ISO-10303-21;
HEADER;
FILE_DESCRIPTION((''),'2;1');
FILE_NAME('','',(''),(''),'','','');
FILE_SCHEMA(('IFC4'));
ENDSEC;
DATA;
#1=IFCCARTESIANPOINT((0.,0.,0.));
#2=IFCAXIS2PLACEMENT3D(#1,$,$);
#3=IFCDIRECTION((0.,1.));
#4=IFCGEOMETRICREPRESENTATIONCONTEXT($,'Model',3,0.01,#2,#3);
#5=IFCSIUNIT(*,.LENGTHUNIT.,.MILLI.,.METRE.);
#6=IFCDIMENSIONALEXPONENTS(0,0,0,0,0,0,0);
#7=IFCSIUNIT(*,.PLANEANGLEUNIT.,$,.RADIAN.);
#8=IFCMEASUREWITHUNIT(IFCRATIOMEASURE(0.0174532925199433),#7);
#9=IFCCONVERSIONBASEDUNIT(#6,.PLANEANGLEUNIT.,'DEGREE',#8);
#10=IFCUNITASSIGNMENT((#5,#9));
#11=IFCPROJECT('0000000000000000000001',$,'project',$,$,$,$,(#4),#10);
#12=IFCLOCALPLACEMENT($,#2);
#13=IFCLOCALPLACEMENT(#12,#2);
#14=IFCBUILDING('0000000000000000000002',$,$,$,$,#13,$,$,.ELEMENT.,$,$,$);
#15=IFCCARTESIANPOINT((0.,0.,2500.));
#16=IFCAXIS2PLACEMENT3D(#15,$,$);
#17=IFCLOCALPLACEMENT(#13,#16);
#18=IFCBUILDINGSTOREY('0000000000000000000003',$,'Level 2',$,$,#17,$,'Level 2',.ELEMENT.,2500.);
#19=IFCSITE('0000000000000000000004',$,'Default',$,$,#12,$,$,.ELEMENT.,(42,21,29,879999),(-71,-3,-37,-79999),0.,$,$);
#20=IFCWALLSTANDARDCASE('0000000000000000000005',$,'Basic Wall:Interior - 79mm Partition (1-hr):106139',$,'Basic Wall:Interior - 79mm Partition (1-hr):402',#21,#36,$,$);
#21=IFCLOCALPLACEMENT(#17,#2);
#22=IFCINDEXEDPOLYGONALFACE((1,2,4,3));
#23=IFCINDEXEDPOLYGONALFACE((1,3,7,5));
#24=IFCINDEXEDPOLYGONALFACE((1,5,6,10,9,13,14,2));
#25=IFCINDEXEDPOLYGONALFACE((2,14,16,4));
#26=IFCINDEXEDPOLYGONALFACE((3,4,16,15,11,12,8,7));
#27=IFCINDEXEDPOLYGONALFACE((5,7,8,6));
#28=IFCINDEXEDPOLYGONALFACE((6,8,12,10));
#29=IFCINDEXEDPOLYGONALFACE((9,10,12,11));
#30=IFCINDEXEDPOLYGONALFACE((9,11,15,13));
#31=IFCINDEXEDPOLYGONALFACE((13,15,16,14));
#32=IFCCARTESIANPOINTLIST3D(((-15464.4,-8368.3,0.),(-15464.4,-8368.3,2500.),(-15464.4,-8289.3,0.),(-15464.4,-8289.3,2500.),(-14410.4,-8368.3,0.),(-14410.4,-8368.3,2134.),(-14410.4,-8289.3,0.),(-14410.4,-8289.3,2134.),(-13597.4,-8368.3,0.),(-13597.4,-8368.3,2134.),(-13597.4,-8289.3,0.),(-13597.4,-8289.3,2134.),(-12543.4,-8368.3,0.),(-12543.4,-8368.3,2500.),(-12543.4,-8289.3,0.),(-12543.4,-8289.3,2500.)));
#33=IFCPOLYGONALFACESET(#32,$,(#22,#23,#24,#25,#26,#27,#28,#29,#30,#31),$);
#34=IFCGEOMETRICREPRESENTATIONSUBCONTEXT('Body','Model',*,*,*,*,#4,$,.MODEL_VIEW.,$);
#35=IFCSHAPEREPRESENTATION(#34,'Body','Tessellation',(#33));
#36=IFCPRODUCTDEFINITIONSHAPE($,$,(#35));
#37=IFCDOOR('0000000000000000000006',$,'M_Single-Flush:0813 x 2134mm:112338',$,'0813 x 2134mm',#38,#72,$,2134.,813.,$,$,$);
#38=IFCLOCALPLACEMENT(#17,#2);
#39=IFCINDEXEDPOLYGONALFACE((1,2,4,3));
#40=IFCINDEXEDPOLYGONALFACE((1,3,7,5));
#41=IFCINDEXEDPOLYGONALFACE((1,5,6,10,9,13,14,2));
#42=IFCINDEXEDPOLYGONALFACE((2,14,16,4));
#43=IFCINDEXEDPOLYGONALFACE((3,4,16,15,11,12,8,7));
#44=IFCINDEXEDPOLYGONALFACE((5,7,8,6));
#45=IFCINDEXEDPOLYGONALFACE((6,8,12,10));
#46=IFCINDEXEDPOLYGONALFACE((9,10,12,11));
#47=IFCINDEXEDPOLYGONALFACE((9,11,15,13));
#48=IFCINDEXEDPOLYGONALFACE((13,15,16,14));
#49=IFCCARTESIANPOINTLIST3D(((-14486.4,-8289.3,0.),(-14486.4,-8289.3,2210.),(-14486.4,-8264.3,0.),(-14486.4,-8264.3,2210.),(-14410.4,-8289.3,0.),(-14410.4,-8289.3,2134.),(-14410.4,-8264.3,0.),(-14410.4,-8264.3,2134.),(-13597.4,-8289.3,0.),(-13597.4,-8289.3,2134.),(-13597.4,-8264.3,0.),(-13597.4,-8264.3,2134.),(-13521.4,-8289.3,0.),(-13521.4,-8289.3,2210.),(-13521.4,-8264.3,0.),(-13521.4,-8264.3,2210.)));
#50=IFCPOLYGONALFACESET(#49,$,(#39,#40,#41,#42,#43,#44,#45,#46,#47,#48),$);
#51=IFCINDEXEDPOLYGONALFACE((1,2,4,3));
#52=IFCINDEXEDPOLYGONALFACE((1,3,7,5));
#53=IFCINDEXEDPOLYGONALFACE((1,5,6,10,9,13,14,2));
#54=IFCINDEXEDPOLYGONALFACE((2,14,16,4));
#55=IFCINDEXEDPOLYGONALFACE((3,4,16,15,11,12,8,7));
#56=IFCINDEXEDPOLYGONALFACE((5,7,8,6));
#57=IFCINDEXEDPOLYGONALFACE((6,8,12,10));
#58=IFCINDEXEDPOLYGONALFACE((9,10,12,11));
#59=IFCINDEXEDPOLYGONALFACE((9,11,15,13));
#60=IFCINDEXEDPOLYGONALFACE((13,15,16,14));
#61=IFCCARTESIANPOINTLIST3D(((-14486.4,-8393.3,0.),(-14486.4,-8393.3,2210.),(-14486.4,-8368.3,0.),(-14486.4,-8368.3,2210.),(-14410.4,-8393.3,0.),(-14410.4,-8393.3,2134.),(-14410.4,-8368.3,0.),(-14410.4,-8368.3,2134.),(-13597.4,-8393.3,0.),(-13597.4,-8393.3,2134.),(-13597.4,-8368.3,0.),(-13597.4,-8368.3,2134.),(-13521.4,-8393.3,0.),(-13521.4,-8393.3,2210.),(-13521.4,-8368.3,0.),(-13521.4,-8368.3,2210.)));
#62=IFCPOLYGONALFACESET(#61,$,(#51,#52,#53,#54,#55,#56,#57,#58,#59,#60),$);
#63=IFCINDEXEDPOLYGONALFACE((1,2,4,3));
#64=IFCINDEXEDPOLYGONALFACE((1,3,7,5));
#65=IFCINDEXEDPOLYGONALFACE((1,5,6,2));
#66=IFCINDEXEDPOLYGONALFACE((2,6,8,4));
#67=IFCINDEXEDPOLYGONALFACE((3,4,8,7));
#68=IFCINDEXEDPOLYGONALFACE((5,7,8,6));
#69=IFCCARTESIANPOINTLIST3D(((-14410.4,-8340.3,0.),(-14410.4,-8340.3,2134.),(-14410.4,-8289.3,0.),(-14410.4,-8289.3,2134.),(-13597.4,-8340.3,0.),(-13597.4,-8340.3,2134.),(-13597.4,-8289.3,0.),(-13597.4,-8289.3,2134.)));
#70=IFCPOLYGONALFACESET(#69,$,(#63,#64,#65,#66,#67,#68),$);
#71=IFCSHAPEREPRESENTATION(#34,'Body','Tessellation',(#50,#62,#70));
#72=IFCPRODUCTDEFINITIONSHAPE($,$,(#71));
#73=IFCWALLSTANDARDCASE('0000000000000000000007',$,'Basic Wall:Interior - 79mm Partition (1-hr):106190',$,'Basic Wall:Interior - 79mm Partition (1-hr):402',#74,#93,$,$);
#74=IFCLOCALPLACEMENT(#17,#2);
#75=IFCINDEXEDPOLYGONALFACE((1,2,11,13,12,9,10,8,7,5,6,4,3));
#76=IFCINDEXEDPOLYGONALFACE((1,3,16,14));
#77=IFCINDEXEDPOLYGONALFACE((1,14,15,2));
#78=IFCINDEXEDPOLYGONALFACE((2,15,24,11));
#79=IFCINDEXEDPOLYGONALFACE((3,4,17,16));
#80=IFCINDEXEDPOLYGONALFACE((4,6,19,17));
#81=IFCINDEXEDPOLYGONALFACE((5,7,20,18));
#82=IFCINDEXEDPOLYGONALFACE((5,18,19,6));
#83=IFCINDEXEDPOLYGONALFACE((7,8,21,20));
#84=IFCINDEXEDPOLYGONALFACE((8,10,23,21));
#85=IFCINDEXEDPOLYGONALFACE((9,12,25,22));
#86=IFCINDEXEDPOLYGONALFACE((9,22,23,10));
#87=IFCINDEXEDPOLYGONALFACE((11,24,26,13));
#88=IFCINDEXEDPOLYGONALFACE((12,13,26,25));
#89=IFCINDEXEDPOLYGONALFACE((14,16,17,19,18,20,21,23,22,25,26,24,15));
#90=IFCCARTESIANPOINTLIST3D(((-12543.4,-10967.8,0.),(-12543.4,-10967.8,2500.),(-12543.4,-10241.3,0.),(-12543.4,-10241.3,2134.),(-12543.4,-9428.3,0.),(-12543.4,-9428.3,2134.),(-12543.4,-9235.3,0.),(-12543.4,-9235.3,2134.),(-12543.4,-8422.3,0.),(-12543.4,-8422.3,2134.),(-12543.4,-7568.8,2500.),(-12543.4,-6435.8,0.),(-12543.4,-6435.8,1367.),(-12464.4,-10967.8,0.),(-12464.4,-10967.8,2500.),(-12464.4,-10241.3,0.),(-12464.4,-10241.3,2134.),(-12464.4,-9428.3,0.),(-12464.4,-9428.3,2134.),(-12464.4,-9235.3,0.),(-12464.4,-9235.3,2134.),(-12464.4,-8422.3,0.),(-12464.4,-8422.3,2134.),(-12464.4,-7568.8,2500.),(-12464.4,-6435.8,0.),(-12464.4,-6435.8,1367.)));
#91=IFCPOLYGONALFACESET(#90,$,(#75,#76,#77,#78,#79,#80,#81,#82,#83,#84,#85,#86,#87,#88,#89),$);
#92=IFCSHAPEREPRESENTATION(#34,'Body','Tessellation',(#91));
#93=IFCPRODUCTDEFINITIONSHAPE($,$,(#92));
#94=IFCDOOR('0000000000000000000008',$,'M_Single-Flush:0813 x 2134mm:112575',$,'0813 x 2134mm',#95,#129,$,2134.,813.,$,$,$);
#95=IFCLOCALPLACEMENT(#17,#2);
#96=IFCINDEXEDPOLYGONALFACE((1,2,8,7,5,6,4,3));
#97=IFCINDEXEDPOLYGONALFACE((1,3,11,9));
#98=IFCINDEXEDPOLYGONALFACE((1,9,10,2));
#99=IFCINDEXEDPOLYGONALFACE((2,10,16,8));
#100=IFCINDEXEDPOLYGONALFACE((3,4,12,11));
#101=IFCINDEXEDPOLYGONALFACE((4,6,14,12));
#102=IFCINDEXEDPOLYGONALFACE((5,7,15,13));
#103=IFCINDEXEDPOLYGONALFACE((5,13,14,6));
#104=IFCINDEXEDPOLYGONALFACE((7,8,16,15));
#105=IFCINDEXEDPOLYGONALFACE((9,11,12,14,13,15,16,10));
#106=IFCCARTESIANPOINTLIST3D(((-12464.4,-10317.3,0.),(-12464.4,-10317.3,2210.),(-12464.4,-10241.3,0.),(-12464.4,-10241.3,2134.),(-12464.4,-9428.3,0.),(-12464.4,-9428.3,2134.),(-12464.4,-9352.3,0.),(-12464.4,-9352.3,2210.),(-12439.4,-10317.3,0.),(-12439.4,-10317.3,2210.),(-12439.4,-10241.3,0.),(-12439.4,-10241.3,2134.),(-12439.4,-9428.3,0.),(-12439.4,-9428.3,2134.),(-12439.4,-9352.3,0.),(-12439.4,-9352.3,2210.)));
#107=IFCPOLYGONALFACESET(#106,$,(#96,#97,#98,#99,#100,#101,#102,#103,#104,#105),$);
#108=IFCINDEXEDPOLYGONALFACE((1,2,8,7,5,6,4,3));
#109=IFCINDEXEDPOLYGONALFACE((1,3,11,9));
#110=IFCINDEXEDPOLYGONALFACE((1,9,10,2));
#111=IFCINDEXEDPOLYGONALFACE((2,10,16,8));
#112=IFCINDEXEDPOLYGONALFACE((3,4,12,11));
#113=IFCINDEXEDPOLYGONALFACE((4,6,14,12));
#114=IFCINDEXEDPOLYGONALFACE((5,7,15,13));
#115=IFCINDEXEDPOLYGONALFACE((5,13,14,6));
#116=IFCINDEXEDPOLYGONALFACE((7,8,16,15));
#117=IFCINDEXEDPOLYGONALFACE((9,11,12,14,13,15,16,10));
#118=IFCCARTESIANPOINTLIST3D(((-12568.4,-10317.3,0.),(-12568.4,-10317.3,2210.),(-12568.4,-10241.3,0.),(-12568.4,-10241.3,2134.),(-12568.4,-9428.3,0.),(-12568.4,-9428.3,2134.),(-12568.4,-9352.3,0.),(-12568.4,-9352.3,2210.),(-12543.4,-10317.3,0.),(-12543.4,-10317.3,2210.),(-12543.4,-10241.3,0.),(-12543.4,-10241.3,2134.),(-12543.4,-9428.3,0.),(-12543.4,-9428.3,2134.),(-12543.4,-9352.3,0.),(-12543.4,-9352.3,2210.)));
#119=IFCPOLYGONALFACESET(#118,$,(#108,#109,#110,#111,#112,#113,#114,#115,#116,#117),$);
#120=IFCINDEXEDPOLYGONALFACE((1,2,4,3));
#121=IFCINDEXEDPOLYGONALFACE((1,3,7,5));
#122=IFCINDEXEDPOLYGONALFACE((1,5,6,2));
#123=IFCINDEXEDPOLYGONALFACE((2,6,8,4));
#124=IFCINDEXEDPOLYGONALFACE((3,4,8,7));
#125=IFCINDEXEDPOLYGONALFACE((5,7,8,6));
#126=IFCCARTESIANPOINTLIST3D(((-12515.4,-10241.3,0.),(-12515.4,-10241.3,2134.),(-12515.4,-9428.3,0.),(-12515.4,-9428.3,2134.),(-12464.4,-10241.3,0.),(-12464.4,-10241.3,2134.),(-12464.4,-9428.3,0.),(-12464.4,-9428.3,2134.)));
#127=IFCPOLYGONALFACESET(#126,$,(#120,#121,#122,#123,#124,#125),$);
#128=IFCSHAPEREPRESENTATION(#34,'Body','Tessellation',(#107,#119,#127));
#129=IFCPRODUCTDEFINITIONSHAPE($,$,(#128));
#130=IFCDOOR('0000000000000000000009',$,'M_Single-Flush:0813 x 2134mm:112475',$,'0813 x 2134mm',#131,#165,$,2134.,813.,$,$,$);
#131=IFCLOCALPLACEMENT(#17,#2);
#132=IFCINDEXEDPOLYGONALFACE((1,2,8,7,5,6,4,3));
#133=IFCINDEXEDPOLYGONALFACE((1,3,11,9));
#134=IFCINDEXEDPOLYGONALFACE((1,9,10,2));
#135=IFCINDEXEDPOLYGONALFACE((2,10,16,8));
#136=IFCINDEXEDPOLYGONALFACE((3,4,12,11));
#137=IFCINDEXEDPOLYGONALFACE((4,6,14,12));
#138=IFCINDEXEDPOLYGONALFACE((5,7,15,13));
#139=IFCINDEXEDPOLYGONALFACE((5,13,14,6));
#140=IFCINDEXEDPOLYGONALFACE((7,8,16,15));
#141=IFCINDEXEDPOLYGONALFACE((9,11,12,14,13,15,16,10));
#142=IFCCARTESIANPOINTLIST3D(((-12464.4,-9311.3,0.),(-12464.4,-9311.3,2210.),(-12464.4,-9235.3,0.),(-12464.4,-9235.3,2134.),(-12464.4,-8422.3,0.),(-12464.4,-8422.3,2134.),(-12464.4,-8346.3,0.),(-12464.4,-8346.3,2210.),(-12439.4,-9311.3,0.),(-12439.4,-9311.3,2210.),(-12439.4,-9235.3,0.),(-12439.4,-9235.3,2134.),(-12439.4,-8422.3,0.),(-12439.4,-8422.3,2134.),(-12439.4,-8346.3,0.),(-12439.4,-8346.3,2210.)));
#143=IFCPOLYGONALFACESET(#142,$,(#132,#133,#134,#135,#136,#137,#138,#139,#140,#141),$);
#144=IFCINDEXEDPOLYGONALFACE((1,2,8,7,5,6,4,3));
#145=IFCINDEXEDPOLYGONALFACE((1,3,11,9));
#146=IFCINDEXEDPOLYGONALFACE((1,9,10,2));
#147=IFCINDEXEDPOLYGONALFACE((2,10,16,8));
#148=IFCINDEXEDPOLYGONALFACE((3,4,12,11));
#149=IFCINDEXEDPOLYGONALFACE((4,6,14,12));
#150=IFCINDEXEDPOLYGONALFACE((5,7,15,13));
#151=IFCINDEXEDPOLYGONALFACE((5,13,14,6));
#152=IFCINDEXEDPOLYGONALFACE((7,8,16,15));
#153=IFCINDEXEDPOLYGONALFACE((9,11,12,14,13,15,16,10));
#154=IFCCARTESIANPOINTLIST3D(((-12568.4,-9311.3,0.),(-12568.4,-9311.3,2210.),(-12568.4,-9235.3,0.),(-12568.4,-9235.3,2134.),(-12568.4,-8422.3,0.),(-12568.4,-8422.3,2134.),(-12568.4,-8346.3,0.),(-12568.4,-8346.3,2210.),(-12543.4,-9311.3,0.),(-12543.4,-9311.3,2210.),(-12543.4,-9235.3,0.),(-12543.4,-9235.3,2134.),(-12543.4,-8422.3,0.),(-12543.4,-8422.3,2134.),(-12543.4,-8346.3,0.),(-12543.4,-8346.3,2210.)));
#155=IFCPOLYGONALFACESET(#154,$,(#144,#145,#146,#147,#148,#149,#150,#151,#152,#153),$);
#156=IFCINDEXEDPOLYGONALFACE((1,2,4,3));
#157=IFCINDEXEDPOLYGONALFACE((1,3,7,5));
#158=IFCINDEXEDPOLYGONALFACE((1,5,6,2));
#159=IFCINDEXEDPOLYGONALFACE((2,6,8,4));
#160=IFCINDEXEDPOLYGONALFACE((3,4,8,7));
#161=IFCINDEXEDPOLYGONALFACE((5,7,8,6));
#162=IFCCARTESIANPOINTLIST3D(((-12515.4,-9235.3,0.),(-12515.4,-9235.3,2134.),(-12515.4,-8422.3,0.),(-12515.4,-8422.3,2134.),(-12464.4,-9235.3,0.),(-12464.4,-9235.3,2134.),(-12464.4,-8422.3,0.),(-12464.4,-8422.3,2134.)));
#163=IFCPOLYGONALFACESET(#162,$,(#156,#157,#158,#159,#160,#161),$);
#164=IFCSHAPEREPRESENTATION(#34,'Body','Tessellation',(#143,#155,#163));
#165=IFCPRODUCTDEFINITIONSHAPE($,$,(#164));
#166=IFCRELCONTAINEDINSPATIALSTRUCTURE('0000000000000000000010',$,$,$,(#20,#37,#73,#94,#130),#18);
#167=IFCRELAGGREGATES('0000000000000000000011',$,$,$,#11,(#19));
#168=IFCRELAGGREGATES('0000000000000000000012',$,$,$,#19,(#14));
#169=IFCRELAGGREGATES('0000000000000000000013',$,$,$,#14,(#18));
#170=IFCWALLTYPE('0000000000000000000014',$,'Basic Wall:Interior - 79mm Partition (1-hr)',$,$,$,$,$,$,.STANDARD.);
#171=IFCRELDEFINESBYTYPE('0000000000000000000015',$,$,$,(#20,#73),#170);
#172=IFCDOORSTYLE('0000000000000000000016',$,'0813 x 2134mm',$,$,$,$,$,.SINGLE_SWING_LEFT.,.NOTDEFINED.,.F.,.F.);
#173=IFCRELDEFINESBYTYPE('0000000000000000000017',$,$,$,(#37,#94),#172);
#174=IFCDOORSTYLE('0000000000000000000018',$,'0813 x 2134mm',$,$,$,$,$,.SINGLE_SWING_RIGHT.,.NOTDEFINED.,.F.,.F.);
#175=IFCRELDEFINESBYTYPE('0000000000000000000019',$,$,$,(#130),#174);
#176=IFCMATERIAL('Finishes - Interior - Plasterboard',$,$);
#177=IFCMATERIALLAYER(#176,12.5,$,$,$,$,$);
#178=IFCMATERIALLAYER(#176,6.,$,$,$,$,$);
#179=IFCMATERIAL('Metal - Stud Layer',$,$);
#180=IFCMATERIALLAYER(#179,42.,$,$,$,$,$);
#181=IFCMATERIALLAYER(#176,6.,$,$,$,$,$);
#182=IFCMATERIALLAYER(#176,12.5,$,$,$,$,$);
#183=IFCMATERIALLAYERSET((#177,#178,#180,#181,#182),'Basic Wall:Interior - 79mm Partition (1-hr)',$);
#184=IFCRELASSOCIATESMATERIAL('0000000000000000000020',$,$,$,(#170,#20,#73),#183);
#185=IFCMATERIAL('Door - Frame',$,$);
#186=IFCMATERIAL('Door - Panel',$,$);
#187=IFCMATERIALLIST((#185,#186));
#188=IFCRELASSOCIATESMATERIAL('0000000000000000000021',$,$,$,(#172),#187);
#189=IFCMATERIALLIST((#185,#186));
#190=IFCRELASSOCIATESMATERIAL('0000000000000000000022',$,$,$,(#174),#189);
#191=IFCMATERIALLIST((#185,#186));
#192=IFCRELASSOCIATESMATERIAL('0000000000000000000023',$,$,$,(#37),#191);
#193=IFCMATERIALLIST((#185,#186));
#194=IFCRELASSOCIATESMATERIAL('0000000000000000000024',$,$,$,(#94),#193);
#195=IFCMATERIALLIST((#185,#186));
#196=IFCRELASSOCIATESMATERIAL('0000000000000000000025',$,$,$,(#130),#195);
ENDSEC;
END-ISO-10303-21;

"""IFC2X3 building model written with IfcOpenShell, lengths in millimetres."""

from ifc_helpers import new_model, entity, si_unit, converted_unit, direction, frame, frame_2d, origin, origin_2d_with_axis, place, context, subcontext, project, spatial, polyline, rectangle, outline, extrude, clip, halfspace, source, transform, mapped, material, material_list, layer, layer_set, layer_usage, type_object, type_shapes, element, fill, save


model = new_model("IFC2X3")

# Units and contexts
model_context = context("Model", 3, precision=0.01, world=origin(), true_north=direction((0.0, 1.0)))
body_context = subcontext(model_context, "Body", "Model", "MODEL_VIEW")
ifc_project = project(units=[si_unit("LENGTHUNIT", "METRE", prefix="MILLI"), converted_unit("PLANEANGLEUNIT", "DEGREE", entity("IfcRatioMeasure", 0.0174532925199433), si_unit("PLANEANGLEUNIT", "RADIAN"), dimensions=[0, 0, 0, 0, 0, 0, 0])], contexts=[model_context])

# Site, building, storey
site_placement = place(None, origin())
site = spatial("IfcSite", under=ifc_project, at=site_placement, Name="Default", CompositionType="ELEMENT", RefLatitude=(42, 21, 29, 879999), RefLongitude=(-71, -3, -37, -79999), RefElevation=0.0)
building_placement = place(site_placement, origin())
building = spatial("IfcBuilding", under=site, at=building_placement, CompositionType="ELEMENT")
storey_placement = place(building_placement, frame((0.0, 0.0, 2500.0)))
storey = spatial("IfcBuildingStorey", under=building, at=storey_placement, Name="Level 2", LongName="Level 2", CompositionType="ELEMENT", Elevation=2500.0)

# Shared definitions
ifc_material_1 = material(Name="Finishes - Interior - Plasterboard")
ifc_layer_1 = layer(ifc_material_1, 12.5)
ifc_layer_2 = layer(ifc_material_1, 6.0)
ifc_material_2 = material(Name="Metal - Stud Layer")
ifc_layer_3 = layer(ifc_material_2, 42.0)
ifc_layer_4 = layer(ifc_material_1, 6.0)
ifc_layer_5 = layer(ifc_material_1, 12.5)
ifc_layer_set_1 = layer_set([ifc_layer_1, ifc_layer_2, ifc_layer_3, ifc_layer_4, ifc_layer_5], Name="Basic Wall:Interior - 79mm Partition (1-hr)")
wall_type_1 = type_object("IfcWallType", Name="Basic Wall:Interior - 79mm Partition (1-hr)", PredefinedType="STANDARD", material=ifc_layer_set_1)

# Shared definitions
ifc_material_3 = material(Name="Door - Frame")
ifc_material_4 = material(Name="Door - Panel")
ifc_material_list_1 = material_list([ifc_material_3, ifc_material_4])
door_style_1 = type_object("IfcDoorStyle", Name="0813 x 2134mm", ConstructionType="NOTDEFINED", OperationType="SINGLE_SWING_LEFT", ParameterTakesPrecedence=False, Sizeable=False, material=ifc_material_list_1)
shared_shape_1 = source(origin(), body_context, "Body", "SweptSolid", [
    extrude(outline(polyline([(-482.5, -1124.0), (482.5, -1124.0), (482.5, 1086.0), (406.5, 1086.0), (406.5, -1048.0), (-406.5, -1048.0), (-406.5, 1086.0), (-482.5, 1086.0), (-482.5, -1124.0)])), frame((406.5, 104.0, 1086.0), z_axis=(0.0, -1.0, 0.0), x_axis=(-1.0, 0.0, 0.0)), (0.0, 0.0, 1.0), 25.0),
    extrude(outline(polyline([(-1124.0, -482.5), (1086.0, -482.5), (1086.0, -406.5), (-1048.0, -406.5), (-1048.0, 406.5), (1086.0, 406.5), (1086.0, 482.5), (-1124.0, 482.5), (-1124.0, -482.5)])), frame((406.5, 0.0, 1086.0), z_axis=(0.0, -1.0, 0.0), x_axis=(0.0, 0.0, -1.0)), (0.0, 0.0, 1.0), 25.0),
    extrude(rectangle(XDim=813.0, YDim=51.0, at=origin_2d_with_axis()), frame((406.5, 53.5, 0.0)), (0.0, 0.0, 1.0), 2134.0),
])
type_shapes(door_style_1, [shared_shape_1])
ifc_material_list_2 = material_list([ifc_material_3, ifc_material_4])
door_style_2 = type_object("IfcDoorStyle", Name="0813 x 2134mm", ConstructionType="NOTDEFINED", OperationType="SINGLE_SWING_RIGHT", ParameterTakesPrecedence=False, Sizeable=False, material=ifc_material_list_2)
shared_shape_2 = source(origin(), body_context, "Body", "SweptSolid", [
    extrude(outline(polyline([(-482.5, -1124.0), (482.5, -1124.0), (482.5, 1086.0), (406.5, 1086.0), (406.5, -1048.0), (-406.5, -1048.0), (-406.5, 1086.0), (-482.5, 1086.0), (-482.5, -1124.0)])), frame((406.5, 79.0, 1086.0), z_axis=(0.0, 1.0, 0.0), x_axis=(1.0, 0.0, 0.0)), (0.0, 0.0, 1.0), 25.0),
    extrude(outline(polyline([(-1124.0, -482.5), (1086.0, -482.5), (1086.0, -406.5), (-1048.0, -406.5), (-1048.0, 406.5), (1086.0, 406.5), (1086.0, 482.5), (-1124.0, 482.5), (-1124.0, -482.5)])), frame((406.5, -25.0, 1086.0), z_axis=(0.0, 1.0, 0.0), x_axis=(0.0, 0.0, -1.0)), (0.0, 0.0, 1.0), 25.0),
    extrude(rectangle(XDim=51.0, YDim=813.0, at=origin_2d_with_axis()), frame((406.5, 53.5, 0.0), z_axis=(0.0, 0.0, 1.0), x_axis=(0.0, 1.0, 0.0)), (0.0, 0.0, 1.0), 2134.0),
])
type_shapes(door_style_2, [shared_shape_2])

# Wall, opening, door
ifc_layer_usage_1 = layer_usage(ifc_layer_set_1, "AXIS2", "NEGATIVE", 39.5)
wall_1_placement = place(storey_placement, frame((-15464.4, -8328.8, 0.0)))
wall_1 = element("IfcWallStandardCase", 1, at=wall_1_placement, inside=storey, type_object=wall_type_1, material=ifc_layer_usage_1, Name="Basic Wall:Interior - 79mm Partition (1-hr):106139", ObjectType="Basic Wall:Interior - 79mm Partition (1-hr):402", context=body_context, shape_type="SweptSolid", body=[
    extrude(rectangle(XDim=2921.0, YDim=79.0, at=frame_2d((1460.5, 0.0), x_axis=(-1.0, 0.0))), origin(), (0.0, 0.0, 1.0), 2500.0),
])
opening_1_placement = place(wall_1_placement, frame((1054.0, -39.5, 0.0)))
opening_1 = element("IfcOpeningElement", 2, at=opening_1_placement, cuts=wall_1, ObjectType="Opening", context=body_context, shape_type="SweptSolid", body=[
    extrude(rectangle(XDim=813.0, YDim=2134.0, at=frame_2d((1067.0, 406.5), x_axis=(0.0, -1.0))), frame((0.0, 0.0, 0.0), z_axis=(0.0, 1.0, 0.0), x_axis=(0.0, 0.0, 1.0)), (0.0, 0.0, 1.0), 79.0),
])
ifc_material_list_3 = material_list([ifc_material_3, ifc_material_4])
door_1_placement = place(opening_1_placement, origin())
door_1 = element("IfcDoor", 3, at=door_1_placement, inside=storey, type_object=door_style_1, material=ifc_material_list_3, Name="M_Single-Flush:0813 x 2134mm:112338", ObjectType="0813 x 2134mm", OverallHeight=2134.0, OverallWidth=813.0, context=body_context, shape_type="MappedRepresentation", body=[
    mapped(shared_shape_1, transform((0.0, 0.0, 0.0), scale=1.0)),
])
fill(opening_1, door_1)

# Wall, openings, doors
ifc_layer_usage_2 = layer_usage(ifc_layer_set_1, "AXIS2", "NEGATIVE", 39.5)
wall_2_placement = place(storey_placement, frame((-12503.9, -10967.8, 0.0), z_axis=(0.0, 0.0, 1.0), x_axis=(0.0, 1.0, 0.0)))
wall_2 = element("IfcWallStandardCase", 4, at=wall_2_placement, inside=storey, type_object=wall_type_1, material=ifc_layer_usage_2, Name="Basic Wall:Interior - 79mm Partition (1-hr):106190", ObjectType="Basic Wall:Interior - 79mm Partition (1-hr):402", context=body_context, shape_type="Clipping", body=[
    clip(extrude(rectangle(XDim=4532.0, YDim=79.0, at=frame_2d((2266.0, 0.0), x_axis=(-1.0, 0.0))), origin(), (0.0, 0.0, 1.0), 2500.0), halfspace(frame((3399.0, -39.5, 2500.0), z_axis=(0.707107, 0.0, 0.707107), x_axis=(0.0, 1.0, 0.0)), False)),
])
opening_2_placement = place(wall_2_placement, frame((2545.5, 39.5, 0.0)))
opening_2 = element("IfcOpeningElement", 5, at=opening_2_placement, cuts=wall_2, ObjectType="Opening", context=body_context, shape_type="SweptSolid", body=[
    extrude(rectangle(XDim=813.0, YDim=2134.0, at=frame_2d((1067.0, 406.5), x_axis=(0.0, 1.0))), frame((0.0, 0.0, 0.0), z_axis=(0.0, -1.0, 0.0), x_axis=(0.0, 0.0, 1.0)), (0.0, 0.0, 1.0), 79.0),
])
opening_3_placement = place(wall_2_placement, frame((1539.5, 39.5, 0.0)))
opening_3 = element("IfcOpeningElement", 6, at=opening_3_placement, cuts=wall_2, ObjectType="Opening", context=body_context, shape_type="SweptSolid", body=[
    extrude(rectangle(XDim=813.0, YDim=2134.0, at=frame_2d((1067.0, 406.5), x_axis=(0.0, -1.0))), frame((0.0, 0.0, 0.0), z_axis=(0.0, -1.0, 0.0), x_axis=(0.0, 0.0, 1.0)), (0.0, 0.0, 1.0), 79.0),
])
ifc_material_list_4 = material_list([ifc_material_3, ifc_material_4])
door_2_placement = place(opening_3_placement, frame((0.0, 0.0, 0.0), z_axis=(0.0, 0.0, 1.0), x_axis=(-1.0, 0.0, 0.0)))
door_2 = element("IfcDoor", 7, at=door_2_placement, inside=storey, type_object=door_style_1, material=ifc_material_list_4, Name="M_Single-Flush:0813 x 2134mm:112575", ObjectType="0813 x 2134mm", OverallHeight=2134.0, OverallWidth=813.0, context=body_context, shape_type="MappedRepresentation", body=[
    mapped(shared_shape_1, transform((0.0, 0.0, 0.0), scale=1.0)),
])
fill(opening_3, door_2)
ifc_material_list_5 = material_list([ifc_material_3, ifc_material_4])
door_3_placement = place(opening_2_placement, frame((0.0, 0.0, 0.0), z_axis=(0.0, 0.0, 1.0), x_axis=(-1.0, 0.0, 0.0)))
door_3 = element("IfcDoor", 8, at=door_3_placement, inside=storey, type_object=door_style_2, material=ifc_material_list_5, Name="M_Single-Flush:0813 x 2134mm:112475", ObjectType="0813 x 2134mm", OverallHeight=2134.0, OverallWidth=813.0, context=body_context, shape_type="MappedRepresentation", body=[
    mapped(shared_shape_2, transform((0.0, 0.0, 0.0), scale=1.0)),
])
fill(opening_2, door_3)

save(model, "model.ifc")
